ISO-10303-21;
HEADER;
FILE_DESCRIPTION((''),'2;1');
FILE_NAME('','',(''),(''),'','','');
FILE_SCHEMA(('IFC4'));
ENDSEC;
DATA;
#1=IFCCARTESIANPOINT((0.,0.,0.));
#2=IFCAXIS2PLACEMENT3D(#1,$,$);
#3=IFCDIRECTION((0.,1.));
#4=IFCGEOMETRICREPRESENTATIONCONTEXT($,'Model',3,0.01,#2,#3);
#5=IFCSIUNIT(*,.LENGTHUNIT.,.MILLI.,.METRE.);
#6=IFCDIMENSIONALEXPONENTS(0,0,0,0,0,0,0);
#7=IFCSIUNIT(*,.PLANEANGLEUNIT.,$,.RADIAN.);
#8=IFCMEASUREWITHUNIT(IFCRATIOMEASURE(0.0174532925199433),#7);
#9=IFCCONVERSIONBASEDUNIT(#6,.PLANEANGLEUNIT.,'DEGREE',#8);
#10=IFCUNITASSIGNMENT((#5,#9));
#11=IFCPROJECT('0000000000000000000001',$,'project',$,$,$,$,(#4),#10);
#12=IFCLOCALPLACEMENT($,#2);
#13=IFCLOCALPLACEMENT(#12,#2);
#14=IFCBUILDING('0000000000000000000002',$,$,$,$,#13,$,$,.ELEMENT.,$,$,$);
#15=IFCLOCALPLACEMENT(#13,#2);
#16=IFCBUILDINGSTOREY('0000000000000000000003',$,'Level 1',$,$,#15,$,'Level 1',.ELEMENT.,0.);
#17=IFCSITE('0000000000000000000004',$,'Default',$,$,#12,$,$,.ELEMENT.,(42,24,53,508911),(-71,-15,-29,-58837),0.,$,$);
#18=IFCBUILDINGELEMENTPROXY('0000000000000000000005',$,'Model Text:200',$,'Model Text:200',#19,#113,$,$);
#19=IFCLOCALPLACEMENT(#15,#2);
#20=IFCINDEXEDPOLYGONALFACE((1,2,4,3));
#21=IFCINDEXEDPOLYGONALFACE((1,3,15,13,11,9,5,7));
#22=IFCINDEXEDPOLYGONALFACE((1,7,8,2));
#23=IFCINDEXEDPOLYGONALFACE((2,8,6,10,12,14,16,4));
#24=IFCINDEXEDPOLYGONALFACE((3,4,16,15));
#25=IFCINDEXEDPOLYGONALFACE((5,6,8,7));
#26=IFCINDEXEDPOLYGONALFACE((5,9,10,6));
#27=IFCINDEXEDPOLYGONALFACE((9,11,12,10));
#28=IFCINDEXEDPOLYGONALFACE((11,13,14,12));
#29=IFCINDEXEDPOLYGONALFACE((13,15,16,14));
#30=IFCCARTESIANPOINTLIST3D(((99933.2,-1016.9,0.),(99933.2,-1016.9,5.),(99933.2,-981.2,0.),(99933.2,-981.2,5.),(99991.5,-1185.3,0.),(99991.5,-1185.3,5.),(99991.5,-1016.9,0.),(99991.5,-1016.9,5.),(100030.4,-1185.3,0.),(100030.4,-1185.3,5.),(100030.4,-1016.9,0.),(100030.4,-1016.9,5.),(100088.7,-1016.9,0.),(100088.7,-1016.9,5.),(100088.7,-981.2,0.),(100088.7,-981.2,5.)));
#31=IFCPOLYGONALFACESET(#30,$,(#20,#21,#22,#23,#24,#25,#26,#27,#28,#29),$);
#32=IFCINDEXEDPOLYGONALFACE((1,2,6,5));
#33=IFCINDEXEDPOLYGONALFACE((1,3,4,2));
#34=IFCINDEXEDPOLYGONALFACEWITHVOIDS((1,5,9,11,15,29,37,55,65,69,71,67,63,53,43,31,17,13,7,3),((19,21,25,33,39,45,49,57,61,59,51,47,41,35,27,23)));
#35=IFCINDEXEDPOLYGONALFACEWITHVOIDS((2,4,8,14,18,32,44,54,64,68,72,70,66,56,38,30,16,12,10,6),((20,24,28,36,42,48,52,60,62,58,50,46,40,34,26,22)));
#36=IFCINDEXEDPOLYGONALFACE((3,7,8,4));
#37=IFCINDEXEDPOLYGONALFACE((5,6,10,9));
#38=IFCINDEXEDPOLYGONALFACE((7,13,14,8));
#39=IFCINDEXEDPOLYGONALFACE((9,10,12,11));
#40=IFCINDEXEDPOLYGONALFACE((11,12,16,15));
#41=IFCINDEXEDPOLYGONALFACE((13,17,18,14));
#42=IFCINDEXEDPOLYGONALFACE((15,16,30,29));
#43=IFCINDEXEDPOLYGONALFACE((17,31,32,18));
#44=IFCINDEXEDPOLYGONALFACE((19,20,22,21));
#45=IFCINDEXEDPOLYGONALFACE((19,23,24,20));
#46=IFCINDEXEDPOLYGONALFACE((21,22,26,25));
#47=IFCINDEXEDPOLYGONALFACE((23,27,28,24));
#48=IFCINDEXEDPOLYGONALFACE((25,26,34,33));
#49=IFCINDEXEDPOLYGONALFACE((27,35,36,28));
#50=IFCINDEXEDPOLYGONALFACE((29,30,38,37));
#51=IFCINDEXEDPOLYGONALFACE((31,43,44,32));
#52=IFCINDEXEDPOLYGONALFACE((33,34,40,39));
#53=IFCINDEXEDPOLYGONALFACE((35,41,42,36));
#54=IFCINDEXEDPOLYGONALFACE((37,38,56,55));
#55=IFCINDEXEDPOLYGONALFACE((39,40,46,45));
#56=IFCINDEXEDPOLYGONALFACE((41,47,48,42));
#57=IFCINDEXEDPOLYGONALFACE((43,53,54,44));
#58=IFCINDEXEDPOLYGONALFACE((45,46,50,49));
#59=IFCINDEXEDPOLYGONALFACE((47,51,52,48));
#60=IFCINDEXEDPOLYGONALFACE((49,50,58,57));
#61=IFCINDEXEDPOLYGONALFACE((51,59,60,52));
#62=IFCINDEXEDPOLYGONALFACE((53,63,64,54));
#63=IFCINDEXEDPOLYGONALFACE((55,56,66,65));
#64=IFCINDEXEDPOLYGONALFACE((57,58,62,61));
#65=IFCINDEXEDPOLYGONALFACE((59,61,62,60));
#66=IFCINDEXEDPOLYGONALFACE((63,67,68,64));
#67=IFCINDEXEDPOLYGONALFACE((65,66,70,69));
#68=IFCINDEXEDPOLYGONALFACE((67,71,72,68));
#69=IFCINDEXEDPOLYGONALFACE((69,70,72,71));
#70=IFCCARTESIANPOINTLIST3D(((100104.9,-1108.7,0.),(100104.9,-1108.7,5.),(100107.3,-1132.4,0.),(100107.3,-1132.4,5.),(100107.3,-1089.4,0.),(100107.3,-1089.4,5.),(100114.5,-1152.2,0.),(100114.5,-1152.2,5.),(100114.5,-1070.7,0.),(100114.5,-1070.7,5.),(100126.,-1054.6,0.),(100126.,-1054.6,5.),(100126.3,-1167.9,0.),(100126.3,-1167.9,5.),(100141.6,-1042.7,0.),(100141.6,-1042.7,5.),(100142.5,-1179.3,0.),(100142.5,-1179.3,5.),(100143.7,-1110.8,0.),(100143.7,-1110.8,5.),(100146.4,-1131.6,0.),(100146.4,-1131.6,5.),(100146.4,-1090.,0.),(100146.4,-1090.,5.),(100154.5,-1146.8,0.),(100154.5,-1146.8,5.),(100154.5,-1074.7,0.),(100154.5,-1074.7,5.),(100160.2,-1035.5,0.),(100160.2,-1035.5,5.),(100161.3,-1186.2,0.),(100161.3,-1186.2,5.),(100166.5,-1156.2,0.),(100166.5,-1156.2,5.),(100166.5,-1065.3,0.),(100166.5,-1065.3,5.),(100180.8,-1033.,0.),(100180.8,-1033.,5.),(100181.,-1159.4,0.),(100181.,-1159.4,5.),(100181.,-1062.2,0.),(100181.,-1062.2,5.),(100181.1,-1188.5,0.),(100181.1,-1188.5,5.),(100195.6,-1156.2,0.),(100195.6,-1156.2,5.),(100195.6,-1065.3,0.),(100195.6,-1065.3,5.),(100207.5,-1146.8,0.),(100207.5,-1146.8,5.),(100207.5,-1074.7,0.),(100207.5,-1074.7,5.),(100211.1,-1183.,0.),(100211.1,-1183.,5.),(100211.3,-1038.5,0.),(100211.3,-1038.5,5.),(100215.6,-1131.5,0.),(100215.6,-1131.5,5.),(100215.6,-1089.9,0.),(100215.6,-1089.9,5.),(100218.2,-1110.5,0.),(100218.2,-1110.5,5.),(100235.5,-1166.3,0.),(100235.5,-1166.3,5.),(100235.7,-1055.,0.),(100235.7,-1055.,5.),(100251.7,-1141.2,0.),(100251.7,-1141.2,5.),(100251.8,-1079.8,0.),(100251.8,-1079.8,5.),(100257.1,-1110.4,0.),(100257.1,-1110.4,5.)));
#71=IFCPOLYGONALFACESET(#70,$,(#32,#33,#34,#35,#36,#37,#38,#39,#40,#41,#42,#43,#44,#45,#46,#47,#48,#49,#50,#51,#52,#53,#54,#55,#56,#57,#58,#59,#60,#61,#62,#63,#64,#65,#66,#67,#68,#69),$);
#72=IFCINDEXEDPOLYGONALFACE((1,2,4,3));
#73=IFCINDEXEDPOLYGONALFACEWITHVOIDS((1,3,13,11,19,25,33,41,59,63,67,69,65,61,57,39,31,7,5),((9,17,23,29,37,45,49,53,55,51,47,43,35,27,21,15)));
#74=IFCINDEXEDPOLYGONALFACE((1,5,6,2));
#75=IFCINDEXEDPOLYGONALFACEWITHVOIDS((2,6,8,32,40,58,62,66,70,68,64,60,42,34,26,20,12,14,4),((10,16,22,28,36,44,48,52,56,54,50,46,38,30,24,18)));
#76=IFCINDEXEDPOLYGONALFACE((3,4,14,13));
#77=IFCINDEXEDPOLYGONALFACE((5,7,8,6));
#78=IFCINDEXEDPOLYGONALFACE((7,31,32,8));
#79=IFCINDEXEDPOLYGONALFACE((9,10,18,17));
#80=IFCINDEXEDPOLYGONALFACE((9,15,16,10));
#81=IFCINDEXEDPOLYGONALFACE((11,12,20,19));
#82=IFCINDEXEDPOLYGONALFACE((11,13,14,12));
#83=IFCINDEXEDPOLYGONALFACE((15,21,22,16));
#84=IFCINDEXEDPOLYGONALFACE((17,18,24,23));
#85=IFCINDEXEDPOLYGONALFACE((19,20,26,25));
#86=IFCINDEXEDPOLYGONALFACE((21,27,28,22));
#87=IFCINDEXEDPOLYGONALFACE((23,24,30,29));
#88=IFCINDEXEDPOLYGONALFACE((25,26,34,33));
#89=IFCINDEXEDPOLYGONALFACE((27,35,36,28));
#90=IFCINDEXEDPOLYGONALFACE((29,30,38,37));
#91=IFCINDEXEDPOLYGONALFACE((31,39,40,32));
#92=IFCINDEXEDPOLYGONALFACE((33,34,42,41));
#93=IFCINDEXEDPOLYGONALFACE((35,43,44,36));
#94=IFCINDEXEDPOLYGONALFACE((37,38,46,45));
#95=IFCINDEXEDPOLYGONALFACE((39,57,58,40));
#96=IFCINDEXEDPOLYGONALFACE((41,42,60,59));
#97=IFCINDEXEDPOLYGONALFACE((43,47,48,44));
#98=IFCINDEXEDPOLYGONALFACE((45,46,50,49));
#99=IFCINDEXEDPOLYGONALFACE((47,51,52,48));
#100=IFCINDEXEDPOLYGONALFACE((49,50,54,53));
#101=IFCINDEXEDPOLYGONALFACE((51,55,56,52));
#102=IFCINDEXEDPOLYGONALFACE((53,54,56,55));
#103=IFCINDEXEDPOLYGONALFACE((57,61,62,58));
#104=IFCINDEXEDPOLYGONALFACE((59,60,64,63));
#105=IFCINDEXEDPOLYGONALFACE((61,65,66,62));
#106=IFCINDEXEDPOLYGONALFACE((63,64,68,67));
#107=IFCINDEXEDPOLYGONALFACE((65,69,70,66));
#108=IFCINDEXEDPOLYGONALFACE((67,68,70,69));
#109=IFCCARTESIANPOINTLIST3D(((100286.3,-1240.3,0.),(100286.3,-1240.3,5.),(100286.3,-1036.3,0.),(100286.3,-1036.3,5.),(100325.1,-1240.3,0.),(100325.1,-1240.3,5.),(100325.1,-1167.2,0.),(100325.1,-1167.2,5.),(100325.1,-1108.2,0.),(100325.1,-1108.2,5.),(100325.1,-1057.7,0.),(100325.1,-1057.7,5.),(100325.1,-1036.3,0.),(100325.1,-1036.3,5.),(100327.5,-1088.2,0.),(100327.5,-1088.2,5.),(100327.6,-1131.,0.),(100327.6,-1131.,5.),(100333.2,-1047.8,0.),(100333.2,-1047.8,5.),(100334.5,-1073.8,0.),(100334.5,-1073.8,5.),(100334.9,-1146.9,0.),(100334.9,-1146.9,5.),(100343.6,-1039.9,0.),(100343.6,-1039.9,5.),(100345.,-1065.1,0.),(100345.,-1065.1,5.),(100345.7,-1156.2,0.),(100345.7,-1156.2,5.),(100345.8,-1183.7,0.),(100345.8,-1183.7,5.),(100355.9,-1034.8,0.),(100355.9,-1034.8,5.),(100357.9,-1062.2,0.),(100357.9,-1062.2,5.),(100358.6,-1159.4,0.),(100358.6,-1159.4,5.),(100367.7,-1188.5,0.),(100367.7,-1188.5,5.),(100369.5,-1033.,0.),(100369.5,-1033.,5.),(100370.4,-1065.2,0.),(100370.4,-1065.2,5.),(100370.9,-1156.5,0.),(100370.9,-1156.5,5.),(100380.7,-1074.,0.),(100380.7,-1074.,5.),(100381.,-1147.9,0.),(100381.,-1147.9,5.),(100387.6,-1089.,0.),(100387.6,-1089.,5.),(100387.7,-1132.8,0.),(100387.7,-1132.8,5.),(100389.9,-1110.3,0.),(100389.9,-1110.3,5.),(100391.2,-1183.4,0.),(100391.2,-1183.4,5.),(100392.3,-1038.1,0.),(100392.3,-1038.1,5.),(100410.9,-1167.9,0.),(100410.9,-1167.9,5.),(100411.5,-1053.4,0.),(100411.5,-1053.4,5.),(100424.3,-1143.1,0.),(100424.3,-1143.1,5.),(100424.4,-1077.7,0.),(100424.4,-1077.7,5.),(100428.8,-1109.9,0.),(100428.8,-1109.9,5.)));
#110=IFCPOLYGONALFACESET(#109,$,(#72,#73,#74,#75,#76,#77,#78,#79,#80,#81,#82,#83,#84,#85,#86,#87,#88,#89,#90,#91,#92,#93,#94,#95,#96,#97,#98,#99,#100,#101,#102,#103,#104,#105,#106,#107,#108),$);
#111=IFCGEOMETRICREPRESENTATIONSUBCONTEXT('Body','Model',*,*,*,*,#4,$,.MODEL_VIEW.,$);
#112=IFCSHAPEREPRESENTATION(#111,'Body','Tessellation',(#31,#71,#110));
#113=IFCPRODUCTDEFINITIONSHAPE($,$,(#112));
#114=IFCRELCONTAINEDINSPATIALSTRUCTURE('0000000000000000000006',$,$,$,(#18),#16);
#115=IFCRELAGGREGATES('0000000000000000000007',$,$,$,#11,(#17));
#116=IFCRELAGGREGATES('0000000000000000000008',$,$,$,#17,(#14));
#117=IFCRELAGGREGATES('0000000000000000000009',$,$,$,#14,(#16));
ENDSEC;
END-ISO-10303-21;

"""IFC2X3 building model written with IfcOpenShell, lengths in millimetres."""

from ifc_helpers import new_model, entity, si_unit, converted_unit, direction, frame, origin, place, context, subcontext, project, spatial, polyline, outline, extrude, element, save


model = new_model("IFC2X3")

# Units and contexts
model_context = context("Model", 3, precision=0.01, world=origin(), true_north=direction((0.0, 1.0)))
body_context = subcontext(model_context, "Body", "Model", "MODEL_VIEW")
ifc_project = project(units=[si_unit("LENGTHUNIT", "METRE", prefix="MILLI"), converted_unit("PLANEANGLEUNIT", "DEGREE", entity("IfcRatioMeasure", 0.0174532925199433), si_unit("PLANEANGLEUNIT", "RADIAN"), dimensions=[0, 0, 0, 0, 0, 0, 0])], contexts=[model_context])

# Site, building, storey
site_placement = place(None, origin())
site = spatial("IfcSite", under=ifc_project, at=site_placement, Name="Default", CompositionType="ELEMENT", RefLatitude=(42, 24, 53, 508911), RefLongitude=(-71, -15, -29, -58837), RefElevation=0.0)
building_placement = place(site_placement, origin())
building = spatial("IfcBuilding", under=site, at=building_placement, CompositionType="ELEMENT")
storey_placement = place(building_placement, origin())
storey = spatial("IfcBuildingStorey", under=building, at=storey_placement, Name="Level 1", LongName="Level 1", CompositionType="ELEMENT", Elevation=0.0)

# Building element proxy
proxy_1_placement = place(storey_placement, origin())
element("IfcBuildingElementProxy", 1, at=proxy_1_placement, inside=storey, Name="Model Text:200", ObjectType="Model Text:200", context=body_context, shape_type="SweptSolid", body=[
    extrude(outline(polyline([(-19.4, -135.2), (19.4, -135.2), (19.4, 33.2), (77.7, 33.2), (77.7, 68.8), (-77.7, 68.8), (-77.7, 33.2), (-19.4, 33.2), (-19.4, -135.2)])), frame((100010.9, -1050.1, 0.0)), (0.0, 0.0, 1.0), 5.0),
    extrude(outline(polyline([(-8.8, -65.7), (15.1, -65.7), (35.5, -60.5), (52.3, -50.4), (65.3, -35.4), (74.1, -17.3), (78.4, 2.1), (75.9, 32.5), (61.8, 58.5), (38.4, 77.1), (8.3, 85.6), (-22.7, 83.3), (-49.0, 69.9), (-67.8, 47.3), (-76.3, 17.5), (-76.0, -3.3), (-70.7, -22.5), (-60.5, -39.2), (-45.5, -52.3), (-27.7, -61.4), (-8.8, -65.7)]), holes=[polyline([(-2.7, -27.2), (-23.1, -22.5), (-37.5, -12.9), (-45.7, 0.0), (-47.3, 14.8), (-42.7, 28.9), (-32.2, 39.9), (-16.3, 46.3), (4.5, 46.9), (25.1, 42.1), (39.6, 32.6), (47.7, 19.7), (49.4, 5.0), (44.8, -9.2), (34.2, -20.2), (18.2, -26.7), (-2.7, -27.2)])]), frame((100171.1, -1110.8, 0.0), z_axis=(0.0, 0.0, 1.0), x_axis=(0.100608, -0.994926, 0.0)), (0.0, 0.0, 1.0), 5.0),
    extrude(outline(polyline([(-73.1, -75.4), (130.9, -75.4), (130.9, -36.6), (57.8, -36.6), (74.3, -15.9), (79.1, 6.0), (73.9, 29.5), (58.4, 49.2), (33.6, 62.6), (0.5, 67.1), (-31.8, 62.8), (-56.1, 49.8), (-71.3, 30.7), (-76.4, 7.8), (-74.7, -5.8), (-69.6, -18.1), (-61.7, -28.5), (-51.7, -36.6), (-73.1, -36.6), (-73.1, -75.4)]), holes=[polyline([(-1.2, -36.6), (-21.2, -34.2), (-35.6, -27.2), (-44.3, -16.7), (-47.2, -3.8), (-44.3, 8.7), (-35.4, 19.0), (-20.4, 25.9), (0.8, 28.2), (23.3, 26.0), (38.5, 19.3), (47.1, 9.2), (49.9, -3.1), (46.8, -16.0), (37.4, -26.8), (21.5, -34.1), (-1.2, -36.6)])]), frame((100361.7, -1109.4, 0.0), z_axis=(0.0, 0.0, 1.0), x_axis=(0.0, -1.0, 0.0)), (0.0, 0.0, 1.0), 5.0),
])

save(model, "model.ifc")
